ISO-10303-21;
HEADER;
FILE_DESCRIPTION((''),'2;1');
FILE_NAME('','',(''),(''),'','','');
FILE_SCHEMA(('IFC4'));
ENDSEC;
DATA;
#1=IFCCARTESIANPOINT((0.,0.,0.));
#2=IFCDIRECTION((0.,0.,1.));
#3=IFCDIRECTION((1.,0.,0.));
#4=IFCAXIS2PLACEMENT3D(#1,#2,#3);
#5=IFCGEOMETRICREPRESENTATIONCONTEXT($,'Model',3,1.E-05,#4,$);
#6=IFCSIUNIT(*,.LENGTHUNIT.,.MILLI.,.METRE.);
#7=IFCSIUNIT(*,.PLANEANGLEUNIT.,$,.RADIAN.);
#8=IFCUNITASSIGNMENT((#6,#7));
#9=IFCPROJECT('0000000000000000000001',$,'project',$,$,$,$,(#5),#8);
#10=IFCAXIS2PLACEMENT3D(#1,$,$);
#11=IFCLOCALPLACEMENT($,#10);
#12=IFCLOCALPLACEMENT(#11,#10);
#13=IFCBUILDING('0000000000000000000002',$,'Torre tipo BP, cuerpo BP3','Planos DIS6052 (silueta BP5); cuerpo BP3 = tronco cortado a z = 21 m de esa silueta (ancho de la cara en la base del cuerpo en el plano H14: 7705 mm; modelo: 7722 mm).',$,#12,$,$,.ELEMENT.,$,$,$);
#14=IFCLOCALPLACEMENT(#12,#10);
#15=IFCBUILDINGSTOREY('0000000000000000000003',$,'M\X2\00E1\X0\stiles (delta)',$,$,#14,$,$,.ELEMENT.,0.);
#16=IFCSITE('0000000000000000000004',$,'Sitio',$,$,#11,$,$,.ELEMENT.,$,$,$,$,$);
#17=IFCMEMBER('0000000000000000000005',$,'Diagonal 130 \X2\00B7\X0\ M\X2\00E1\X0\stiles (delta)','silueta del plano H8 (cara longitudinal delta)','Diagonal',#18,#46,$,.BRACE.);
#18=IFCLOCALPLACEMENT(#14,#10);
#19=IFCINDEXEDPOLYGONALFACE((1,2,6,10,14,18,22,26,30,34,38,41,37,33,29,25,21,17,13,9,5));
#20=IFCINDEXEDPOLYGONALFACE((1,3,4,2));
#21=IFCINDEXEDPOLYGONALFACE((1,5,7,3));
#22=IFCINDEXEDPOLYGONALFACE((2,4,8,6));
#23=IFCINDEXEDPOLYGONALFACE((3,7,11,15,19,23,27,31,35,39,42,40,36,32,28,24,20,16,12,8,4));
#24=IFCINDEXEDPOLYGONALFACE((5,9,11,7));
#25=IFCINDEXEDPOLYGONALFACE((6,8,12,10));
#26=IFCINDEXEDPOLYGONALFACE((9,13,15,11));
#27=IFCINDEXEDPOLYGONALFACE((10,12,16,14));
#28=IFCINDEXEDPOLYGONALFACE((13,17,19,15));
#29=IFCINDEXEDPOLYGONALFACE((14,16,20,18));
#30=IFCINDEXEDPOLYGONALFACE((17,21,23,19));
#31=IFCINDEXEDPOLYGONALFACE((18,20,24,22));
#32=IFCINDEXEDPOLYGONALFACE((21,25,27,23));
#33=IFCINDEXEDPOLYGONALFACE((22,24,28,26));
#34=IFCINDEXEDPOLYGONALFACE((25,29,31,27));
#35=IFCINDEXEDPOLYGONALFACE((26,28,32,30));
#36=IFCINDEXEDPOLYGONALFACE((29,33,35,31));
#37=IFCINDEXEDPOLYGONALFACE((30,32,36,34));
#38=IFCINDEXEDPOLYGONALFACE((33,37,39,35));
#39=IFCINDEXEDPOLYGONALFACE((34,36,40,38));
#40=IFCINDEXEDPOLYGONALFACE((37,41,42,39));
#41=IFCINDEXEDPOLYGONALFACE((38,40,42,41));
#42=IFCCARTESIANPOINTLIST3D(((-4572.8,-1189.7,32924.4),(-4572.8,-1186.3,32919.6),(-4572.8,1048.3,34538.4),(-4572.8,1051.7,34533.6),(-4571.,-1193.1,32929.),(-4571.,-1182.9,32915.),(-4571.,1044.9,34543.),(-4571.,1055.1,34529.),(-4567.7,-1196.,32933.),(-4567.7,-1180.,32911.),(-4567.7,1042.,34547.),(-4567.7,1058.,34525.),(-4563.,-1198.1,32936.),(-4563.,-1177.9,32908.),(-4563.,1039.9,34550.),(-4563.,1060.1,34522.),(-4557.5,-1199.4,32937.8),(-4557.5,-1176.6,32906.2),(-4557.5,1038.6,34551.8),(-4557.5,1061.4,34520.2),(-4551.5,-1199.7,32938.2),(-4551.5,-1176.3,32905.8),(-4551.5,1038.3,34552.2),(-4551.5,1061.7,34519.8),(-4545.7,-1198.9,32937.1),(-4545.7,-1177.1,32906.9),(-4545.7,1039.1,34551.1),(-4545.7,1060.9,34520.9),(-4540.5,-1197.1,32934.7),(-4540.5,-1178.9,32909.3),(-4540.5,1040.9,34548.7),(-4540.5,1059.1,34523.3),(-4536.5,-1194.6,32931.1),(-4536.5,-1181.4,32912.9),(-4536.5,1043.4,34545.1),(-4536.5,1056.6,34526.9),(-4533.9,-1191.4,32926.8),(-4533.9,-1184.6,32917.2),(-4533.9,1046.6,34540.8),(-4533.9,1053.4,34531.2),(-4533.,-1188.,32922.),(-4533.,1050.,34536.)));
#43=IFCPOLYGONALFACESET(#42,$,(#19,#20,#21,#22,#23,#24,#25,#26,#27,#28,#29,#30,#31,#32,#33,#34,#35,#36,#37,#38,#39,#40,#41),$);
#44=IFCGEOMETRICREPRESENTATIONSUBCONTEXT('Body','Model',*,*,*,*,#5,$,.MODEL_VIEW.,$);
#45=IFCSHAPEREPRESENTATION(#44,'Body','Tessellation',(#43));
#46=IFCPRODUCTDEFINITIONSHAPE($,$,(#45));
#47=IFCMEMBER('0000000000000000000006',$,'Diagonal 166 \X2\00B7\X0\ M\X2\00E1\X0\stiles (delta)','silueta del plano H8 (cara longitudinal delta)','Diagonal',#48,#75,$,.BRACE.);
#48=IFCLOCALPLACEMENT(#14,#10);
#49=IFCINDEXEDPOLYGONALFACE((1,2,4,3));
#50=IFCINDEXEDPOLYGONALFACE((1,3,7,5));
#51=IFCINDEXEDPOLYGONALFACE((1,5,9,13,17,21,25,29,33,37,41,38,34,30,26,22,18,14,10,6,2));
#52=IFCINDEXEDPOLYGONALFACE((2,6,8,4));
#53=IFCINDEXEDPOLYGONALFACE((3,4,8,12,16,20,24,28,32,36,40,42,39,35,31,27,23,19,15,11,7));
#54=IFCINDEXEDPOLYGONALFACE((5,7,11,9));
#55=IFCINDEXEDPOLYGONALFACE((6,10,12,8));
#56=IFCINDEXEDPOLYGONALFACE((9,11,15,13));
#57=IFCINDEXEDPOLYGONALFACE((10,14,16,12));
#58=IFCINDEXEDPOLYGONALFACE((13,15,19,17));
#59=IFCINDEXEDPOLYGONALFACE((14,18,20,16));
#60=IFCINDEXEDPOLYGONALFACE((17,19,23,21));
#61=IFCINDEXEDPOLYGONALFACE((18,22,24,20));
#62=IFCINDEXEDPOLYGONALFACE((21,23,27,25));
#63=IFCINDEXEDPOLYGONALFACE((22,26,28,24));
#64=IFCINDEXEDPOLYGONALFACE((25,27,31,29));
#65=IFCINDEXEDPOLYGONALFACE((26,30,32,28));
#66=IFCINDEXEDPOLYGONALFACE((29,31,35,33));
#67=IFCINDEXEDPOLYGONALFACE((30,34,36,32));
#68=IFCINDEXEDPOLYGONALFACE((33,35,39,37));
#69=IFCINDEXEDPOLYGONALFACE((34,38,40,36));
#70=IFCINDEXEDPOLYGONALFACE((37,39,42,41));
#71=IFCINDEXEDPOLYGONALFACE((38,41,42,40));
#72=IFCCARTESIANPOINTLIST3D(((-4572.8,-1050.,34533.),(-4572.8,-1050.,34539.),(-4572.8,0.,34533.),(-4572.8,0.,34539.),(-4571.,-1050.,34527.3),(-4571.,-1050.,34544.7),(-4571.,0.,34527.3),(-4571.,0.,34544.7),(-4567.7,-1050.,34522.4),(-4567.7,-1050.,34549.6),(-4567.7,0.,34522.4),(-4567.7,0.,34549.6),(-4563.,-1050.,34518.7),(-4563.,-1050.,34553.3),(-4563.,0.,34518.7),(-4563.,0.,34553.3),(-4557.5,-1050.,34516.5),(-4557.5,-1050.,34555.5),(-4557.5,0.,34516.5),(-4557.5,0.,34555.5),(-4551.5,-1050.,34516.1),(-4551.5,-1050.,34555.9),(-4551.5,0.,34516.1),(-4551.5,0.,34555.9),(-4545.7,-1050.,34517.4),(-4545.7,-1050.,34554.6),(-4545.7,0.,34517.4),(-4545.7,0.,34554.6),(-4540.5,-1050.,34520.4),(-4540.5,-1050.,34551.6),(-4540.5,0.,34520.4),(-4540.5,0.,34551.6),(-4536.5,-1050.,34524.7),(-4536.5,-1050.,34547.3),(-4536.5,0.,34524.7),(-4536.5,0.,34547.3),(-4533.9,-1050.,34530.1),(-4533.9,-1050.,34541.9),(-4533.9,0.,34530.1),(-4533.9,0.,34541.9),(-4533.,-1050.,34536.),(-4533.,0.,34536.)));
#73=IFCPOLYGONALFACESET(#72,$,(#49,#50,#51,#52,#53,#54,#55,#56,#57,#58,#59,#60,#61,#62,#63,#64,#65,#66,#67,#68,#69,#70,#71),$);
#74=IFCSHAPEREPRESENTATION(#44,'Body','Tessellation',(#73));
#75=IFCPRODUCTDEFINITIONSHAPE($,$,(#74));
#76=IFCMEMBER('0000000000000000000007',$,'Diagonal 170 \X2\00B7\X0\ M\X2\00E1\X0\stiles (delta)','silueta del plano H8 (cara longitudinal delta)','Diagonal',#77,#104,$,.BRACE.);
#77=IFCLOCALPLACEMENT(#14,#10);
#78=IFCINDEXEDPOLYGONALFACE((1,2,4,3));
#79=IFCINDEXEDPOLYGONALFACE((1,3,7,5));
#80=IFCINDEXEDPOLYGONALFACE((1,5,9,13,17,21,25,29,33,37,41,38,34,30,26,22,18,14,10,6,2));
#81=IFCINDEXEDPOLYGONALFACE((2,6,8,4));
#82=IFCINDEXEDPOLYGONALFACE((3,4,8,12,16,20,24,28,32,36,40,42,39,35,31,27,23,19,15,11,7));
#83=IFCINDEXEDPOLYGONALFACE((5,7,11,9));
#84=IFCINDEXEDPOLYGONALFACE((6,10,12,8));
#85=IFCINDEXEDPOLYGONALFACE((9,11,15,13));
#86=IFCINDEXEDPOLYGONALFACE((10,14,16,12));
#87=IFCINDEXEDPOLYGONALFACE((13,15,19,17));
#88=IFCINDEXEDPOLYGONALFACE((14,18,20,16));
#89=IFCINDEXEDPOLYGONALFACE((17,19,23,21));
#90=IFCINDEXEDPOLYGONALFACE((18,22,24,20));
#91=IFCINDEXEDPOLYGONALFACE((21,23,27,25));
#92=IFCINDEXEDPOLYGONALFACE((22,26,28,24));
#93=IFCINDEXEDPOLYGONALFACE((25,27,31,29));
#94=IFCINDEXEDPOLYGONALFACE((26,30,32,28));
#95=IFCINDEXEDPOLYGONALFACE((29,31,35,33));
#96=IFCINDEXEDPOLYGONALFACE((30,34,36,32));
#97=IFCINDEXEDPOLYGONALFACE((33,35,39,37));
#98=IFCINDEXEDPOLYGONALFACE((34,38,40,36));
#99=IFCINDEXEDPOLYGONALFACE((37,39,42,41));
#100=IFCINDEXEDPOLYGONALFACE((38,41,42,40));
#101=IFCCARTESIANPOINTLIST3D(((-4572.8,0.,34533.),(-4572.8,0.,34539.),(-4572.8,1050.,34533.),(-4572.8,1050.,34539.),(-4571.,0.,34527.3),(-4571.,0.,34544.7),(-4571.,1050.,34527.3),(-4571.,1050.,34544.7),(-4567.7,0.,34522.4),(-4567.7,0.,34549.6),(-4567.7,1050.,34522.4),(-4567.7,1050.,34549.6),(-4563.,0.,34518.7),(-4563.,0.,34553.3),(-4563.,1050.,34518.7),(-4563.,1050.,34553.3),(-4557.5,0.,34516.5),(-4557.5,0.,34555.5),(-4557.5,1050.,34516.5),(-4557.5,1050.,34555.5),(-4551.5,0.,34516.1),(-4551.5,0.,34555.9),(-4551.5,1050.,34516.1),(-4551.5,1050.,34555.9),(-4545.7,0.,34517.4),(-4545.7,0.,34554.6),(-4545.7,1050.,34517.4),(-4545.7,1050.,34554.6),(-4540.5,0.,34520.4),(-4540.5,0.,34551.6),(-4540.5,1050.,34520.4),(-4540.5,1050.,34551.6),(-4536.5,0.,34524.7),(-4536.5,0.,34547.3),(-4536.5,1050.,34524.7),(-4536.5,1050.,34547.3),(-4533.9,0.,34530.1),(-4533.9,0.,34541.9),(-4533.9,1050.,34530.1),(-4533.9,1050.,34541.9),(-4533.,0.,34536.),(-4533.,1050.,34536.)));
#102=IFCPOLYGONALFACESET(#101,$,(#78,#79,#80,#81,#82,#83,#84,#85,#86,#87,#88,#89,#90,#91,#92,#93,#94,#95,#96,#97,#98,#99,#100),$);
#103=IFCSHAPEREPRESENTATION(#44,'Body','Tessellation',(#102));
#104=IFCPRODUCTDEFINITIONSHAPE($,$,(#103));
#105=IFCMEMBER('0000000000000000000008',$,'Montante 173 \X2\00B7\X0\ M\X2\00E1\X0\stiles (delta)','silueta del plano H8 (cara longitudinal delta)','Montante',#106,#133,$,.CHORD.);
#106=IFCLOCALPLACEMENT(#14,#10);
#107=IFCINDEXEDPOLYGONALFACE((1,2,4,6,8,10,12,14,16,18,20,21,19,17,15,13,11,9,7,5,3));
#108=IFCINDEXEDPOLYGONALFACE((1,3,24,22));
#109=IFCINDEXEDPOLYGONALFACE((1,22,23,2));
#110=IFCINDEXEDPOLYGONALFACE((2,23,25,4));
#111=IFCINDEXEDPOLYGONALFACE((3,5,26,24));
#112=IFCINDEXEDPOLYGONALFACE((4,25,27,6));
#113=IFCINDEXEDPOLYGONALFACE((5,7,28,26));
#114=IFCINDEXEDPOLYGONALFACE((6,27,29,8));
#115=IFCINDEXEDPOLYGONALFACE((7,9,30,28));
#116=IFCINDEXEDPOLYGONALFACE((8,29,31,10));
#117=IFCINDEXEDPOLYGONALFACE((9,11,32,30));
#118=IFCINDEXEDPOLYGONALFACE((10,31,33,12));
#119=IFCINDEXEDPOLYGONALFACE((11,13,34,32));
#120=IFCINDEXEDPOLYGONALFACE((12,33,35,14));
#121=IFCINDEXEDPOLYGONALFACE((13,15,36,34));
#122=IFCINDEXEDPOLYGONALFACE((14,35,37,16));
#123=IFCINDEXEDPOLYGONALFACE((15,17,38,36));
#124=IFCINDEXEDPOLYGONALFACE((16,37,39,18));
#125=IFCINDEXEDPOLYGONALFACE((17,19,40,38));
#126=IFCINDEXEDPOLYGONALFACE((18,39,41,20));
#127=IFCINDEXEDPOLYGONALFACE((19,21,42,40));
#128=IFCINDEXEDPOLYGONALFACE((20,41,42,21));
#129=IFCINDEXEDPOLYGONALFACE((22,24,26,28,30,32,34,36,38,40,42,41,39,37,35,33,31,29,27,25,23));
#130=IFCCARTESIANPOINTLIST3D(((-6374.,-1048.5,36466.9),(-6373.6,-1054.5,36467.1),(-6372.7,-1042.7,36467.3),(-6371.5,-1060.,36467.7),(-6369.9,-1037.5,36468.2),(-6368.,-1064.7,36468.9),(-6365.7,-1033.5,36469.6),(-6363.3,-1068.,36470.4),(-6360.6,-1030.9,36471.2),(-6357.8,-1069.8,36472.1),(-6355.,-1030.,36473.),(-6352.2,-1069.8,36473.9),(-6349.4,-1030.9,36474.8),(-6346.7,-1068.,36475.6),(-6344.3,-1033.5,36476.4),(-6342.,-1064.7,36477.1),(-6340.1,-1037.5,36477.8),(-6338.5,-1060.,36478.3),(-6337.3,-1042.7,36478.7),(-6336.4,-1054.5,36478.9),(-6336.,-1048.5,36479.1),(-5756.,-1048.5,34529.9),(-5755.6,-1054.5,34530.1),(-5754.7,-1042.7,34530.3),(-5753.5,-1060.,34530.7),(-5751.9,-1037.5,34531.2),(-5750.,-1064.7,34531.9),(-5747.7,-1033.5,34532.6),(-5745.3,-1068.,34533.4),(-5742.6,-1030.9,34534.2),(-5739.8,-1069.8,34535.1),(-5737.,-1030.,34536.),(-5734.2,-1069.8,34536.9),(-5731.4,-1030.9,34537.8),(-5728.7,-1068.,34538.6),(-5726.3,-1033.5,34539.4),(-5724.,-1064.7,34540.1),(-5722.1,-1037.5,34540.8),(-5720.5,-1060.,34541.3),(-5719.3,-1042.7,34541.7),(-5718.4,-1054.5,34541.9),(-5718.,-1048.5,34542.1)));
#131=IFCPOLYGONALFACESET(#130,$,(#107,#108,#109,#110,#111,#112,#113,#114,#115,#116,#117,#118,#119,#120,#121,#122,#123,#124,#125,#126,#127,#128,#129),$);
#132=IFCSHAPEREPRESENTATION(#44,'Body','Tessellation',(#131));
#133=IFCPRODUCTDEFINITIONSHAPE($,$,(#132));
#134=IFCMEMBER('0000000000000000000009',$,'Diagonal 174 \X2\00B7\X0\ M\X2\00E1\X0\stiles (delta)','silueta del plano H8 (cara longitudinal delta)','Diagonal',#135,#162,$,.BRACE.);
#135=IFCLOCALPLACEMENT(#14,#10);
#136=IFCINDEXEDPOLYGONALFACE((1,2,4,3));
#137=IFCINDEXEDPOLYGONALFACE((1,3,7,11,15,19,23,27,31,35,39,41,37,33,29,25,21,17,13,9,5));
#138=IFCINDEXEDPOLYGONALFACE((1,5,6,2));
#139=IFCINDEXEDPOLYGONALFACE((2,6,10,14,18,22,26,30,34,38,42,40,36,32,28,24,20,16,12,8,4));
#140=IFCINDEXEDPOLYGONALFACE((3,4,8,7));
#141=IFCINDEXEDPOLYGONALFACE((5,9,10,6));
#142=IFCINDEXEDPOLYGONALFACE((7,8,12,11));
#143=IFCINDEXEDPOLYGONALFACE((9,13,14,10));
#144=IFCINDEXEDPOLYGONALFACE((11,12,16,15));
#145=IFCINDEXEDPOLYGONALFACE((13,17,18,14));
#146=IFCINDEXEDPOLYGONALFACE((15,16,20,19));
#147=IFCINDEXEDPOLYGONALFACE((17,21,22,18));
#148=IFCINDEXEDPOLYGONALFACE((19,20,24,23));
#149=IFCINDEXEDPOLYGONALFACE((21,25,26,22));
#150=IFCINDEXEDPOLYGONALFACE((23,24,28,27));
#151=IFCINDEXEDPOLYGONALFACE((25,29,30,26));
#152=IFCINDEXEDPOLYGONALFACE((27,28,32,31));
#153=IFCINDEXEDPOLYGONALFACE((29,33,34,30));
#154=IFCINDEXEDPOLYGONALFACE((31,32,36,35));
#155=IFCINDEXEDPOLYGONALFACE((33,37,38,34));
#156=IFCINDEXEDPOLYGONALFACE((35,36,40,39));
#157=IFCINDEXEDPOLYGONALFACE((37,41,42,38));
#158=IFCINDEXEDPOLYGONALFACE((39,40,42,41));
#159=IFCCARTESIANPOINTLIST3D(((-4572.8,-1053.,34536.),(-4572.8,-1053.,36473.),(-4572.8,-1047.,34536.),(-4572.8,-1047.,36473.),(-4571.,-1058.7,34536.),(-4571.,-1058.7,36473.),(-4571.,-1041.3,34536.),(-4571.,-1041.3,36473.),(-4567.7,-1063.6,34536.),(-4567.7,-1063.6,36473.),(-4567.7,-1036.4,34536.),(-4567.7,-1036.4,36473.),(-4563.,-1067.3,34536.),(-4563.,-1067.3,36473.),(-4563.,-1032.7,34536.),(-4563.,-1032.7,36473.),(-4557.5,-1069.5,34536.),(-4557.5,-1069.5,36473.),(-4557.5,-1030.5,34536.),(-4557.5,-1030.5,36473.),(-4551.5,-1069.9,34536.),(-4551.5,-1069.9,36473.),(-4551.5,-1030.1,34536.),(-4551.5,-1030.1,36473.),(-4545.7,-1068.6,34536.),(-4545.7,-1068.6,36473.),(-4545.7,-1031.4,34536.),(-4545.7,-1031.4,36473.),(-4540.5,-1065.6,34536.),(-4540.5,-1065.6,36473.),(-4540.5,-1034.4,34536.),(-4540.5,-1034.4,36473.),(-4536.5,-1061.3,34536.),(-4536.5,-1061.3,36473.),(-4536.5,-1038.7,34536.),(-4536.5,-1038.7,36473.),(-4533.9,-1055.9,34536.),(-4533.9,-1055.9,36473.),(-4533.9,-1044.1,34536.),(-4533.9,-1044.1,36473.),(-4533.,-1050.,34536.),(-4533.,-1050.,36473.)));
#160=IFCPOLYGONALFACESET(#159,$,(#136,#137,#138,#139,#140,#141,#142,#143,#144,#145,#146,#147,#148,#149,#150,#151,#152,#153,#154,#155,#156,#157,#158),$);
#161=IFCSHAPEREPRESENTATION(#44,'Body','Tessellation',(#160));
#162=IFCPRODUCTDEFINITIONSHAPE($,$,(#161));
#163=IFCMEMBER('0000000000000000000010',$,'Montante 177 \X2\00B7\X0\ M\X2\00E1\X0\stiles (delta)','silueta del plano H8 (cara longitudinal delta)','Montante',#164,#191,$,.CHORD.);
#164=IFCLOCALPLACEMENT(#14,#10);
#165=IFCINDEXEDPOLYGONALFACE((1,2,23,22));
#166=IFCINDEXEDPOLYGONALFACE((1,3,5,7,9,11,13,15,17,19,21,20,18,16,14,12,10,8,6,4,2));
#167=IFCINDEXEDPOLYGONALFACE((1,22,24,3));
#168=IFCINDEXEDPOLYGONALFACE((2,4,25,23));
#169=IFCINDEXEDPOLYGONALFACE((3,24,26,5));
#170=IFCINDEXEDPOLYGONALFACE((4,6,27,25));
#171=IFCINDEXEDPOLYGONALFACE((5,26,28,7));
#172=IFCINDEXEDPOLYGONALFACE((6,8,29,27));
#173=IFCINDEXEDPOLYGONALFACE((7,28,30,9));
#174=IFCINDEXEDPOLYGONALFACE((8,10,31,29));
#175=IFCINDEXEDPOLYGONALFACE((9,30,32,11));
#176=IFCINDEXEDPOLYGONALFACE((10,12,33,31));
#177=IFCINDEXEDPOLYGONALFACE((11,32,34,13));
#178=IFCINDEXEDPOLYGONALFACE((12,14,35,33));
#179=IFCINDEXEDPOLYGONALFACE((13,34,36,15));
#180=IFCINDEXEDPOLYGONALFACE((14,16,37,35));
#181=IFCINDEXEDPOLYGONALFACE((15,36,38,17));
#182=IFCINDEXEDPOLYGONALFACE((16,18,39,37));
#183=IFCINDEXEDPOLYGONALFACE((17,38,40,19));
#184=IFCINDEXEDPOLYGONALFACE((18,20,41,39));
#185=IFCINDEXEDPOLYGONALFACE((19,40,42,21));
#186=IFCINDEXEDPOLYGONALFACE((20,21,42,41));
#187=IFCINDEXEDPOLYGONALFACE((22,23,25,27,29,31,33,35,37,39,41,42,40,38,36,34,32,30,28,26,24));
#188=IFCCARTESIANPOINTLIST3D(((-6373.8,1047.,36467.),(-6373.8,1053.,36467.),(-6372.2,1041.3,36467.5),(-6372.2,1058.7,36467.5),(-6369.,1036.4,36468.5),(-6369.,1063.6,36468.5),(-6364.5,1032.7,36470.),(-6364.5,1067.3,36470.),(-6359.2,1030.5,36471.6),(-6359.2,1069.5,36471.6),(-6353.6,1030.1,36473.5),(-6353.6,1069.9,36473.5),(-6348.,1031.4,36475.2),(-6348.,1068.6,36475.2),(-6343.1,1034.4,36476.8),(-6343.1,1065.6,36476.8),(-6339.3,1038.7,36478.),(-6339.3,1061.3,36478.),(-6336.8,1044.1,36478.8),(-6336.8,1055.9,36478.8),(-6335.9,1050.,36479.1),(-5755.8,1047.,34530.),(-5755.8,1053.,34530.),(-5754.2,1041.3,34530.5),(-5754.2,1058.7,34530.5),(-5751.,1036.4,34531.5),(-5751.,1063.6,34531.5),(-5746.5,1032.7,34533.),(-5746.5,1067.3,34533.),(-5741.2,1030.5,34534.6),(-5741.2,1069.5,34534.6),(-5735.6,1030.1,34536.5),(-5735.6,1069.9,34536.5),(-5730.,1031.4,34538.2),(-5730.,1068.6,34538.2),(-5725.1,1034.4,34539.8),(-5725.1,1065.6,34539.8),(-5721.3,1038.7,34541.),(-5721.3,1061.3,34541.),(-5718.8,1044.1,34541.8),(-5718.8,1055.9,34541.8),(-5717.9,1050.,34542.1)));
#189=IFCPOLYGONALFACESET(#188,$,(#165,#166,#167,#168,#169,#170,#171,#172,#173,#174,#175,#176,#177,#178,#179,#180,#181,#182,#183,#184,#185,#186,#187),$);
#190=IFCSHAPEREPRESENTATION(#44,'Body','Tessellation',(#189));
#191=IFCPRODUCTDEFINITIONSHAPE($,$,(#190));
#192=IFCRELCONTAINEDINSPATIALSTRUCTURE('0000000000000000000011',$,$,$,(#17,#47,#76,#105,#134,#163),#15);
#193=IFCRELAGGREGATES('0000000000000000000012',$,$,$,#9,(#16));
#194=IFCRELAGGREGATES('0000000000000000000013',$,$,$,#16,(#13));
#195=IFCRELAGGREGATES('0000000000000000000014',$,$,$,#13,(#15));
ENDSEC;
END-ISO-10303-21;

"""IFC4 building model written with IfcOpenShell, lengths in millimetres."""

from ifc_helpers import new_model, si_unit, frame, origin, origin_with_axes, place, context, subcontext, project, spatial, circle, extrude, element, save


model = new_model("IFC4")

# Units and contexts
model_context = context("Model", 3, precision=1e-05, world=origin_with_axes())
body_context = subcontext(model_context, "Body", "Model", "MODEL_VIEW")
ifc_project = project(units=[si_unit("LENGTHUNIT", "METRE", prefix="MILLI"), si_unit("PLANEANGLEUNIT", "RADIAN")], contexts=[model_context])

# Site, building, storey
site_placement = place(None, origin())
site = spatial("IfcSite", under=ifc_project, at=site_placement, Name="Sitio", CompositionType="ELEMENT")
building_placement = place(site_placement, origin())
building = spatial("IfcBuilding", under=site, at=building_placement, Name="Torre tipo BP, cuerpo BP3", Description="Planos DIS6052 (silueta BP5); cuerpo BP3 = tronco cortado a z = 21 m de esa silueta (ancho de la cara en la base del cuerpo en el plano H14: 7705 mm; modelo: 7722 mm).", CompositionType="ELEMENT")
storey_placement = place(building_placement, origin())
storey = spatial("IfcBuildingStorey", under=building, at=storey_placement, Name="Mástiles (delta)", CompositionType="ELEMENT", Elevation=0.0)

# Members
member_1_placement = place(storey_placement, frame((-4553.0, 1050.0, 34536.0), z_axis=(0.0, -0.81108, -0.584935), x_axis=(1.0, 0.0, 0.0)))
element("IfcMember", 1, at=member_1_placement, inside=storey, Name="Diagonal 130 · Mástiles (delta)", Description="silueta del plano H8 (cara longitudinal delta)", ObjectType="Diagonal", PredefinedType="BRACE", context=body_context, shape_type="SweptSolid", body=[
    extrude(circle(Radius=20.0), None, (0.0, 0.0, 1.0), 2759.3),
])
for number, where, z_axis, x_axis, name in (
    (2, (-4553.0, -1050.0, 34536.0), (0.0, 1.0, 0.0), (1.0, 0.0, 0.0), "Diagonal 166 · Mástiles (delta)"),
    (3, (-4553.0, 1050.0, 34536.0), (0.0, -1.0, 0.0), (1.0, 0.0, 0.0), "Diagonal 170 · Mástiles (delta)"),
):
    element("IfcMember", number, at=place(storey_placement, frame(where, z_axis=z_axis, x_axis=x_axis)), inside=storey, Name=name, Description="silueta del plano H8 (cara longitudinal delta)", ObjectType="Diagonal", PredefinedType="BRACE", context=body_context, shape_type="SweptSolid", body=[
        extrude(circle(Radius=20.0), None, (0.0, 0.0, 1.0), 1050.0),
    ])
member_2_placement = place(storey_placement, frame((-6355.0, -1050.0, 36473.0), z_axis=(0.303955, 0.0, -0.952686), x_axis=(0.0, 1.0, 0.0)))
element("IfcMember", 4, at=member_2_placement, inside=storey, Name="Montante 173 · Mástiles (delta)", Description="silueta del plano H8 (cara longitudinal delta)", ObjectType="Montante", PredefinedType="CHORD", context=body_context, shape_type="SweptSolid", body=[
    extrude(circle(Radius=20.0), None, (0.0, 0.0, 1.0), 2033.2),
])
member_3_placement = place(storey_placement, frame((-4553.0, -1050.0, 36473.0), z_axis=(0.0, 0.0, -1.0), x_axis=(1.0, 0.0, 0.0)))
element("IfcMember", 5, at=member_3_placement, inside=storey, Name="Diagonal 174 · Mástiles (delta)", Description="silueta del plano H8 (cara longitudinal delta)", ObjectType="Diagonal", PredefinedType="BRACE", context=body_context, shape_type="SweptSolid", body=[
    extrude(circle(Radius=20.0), None, (0.0, 0.0, 1.0), 1937.0),
])
member_4_placement = place(storey_placement, frame((-6355.0, 1050.0, 36473.0), z_axis=(0.303955, 0.0, -0.952686), x_axis=(0.952686, 0.0, 0.303955)))
element("IfcMember", 6, at=member_4_placement, inside=storey, Name="Montante 177 · Mástiles (delta)", Description="silueta del plano H8 (cara longitudinal delta)", ObjectType="Montante", PredefinedType="CHORD", context=body_context, shape_type="SweptSolid", body=[
    extrude(circle(Radius=20.0), None, (0.0, 0.0, 1.0), 2033.2),
])

save(model, "model.ifc")
